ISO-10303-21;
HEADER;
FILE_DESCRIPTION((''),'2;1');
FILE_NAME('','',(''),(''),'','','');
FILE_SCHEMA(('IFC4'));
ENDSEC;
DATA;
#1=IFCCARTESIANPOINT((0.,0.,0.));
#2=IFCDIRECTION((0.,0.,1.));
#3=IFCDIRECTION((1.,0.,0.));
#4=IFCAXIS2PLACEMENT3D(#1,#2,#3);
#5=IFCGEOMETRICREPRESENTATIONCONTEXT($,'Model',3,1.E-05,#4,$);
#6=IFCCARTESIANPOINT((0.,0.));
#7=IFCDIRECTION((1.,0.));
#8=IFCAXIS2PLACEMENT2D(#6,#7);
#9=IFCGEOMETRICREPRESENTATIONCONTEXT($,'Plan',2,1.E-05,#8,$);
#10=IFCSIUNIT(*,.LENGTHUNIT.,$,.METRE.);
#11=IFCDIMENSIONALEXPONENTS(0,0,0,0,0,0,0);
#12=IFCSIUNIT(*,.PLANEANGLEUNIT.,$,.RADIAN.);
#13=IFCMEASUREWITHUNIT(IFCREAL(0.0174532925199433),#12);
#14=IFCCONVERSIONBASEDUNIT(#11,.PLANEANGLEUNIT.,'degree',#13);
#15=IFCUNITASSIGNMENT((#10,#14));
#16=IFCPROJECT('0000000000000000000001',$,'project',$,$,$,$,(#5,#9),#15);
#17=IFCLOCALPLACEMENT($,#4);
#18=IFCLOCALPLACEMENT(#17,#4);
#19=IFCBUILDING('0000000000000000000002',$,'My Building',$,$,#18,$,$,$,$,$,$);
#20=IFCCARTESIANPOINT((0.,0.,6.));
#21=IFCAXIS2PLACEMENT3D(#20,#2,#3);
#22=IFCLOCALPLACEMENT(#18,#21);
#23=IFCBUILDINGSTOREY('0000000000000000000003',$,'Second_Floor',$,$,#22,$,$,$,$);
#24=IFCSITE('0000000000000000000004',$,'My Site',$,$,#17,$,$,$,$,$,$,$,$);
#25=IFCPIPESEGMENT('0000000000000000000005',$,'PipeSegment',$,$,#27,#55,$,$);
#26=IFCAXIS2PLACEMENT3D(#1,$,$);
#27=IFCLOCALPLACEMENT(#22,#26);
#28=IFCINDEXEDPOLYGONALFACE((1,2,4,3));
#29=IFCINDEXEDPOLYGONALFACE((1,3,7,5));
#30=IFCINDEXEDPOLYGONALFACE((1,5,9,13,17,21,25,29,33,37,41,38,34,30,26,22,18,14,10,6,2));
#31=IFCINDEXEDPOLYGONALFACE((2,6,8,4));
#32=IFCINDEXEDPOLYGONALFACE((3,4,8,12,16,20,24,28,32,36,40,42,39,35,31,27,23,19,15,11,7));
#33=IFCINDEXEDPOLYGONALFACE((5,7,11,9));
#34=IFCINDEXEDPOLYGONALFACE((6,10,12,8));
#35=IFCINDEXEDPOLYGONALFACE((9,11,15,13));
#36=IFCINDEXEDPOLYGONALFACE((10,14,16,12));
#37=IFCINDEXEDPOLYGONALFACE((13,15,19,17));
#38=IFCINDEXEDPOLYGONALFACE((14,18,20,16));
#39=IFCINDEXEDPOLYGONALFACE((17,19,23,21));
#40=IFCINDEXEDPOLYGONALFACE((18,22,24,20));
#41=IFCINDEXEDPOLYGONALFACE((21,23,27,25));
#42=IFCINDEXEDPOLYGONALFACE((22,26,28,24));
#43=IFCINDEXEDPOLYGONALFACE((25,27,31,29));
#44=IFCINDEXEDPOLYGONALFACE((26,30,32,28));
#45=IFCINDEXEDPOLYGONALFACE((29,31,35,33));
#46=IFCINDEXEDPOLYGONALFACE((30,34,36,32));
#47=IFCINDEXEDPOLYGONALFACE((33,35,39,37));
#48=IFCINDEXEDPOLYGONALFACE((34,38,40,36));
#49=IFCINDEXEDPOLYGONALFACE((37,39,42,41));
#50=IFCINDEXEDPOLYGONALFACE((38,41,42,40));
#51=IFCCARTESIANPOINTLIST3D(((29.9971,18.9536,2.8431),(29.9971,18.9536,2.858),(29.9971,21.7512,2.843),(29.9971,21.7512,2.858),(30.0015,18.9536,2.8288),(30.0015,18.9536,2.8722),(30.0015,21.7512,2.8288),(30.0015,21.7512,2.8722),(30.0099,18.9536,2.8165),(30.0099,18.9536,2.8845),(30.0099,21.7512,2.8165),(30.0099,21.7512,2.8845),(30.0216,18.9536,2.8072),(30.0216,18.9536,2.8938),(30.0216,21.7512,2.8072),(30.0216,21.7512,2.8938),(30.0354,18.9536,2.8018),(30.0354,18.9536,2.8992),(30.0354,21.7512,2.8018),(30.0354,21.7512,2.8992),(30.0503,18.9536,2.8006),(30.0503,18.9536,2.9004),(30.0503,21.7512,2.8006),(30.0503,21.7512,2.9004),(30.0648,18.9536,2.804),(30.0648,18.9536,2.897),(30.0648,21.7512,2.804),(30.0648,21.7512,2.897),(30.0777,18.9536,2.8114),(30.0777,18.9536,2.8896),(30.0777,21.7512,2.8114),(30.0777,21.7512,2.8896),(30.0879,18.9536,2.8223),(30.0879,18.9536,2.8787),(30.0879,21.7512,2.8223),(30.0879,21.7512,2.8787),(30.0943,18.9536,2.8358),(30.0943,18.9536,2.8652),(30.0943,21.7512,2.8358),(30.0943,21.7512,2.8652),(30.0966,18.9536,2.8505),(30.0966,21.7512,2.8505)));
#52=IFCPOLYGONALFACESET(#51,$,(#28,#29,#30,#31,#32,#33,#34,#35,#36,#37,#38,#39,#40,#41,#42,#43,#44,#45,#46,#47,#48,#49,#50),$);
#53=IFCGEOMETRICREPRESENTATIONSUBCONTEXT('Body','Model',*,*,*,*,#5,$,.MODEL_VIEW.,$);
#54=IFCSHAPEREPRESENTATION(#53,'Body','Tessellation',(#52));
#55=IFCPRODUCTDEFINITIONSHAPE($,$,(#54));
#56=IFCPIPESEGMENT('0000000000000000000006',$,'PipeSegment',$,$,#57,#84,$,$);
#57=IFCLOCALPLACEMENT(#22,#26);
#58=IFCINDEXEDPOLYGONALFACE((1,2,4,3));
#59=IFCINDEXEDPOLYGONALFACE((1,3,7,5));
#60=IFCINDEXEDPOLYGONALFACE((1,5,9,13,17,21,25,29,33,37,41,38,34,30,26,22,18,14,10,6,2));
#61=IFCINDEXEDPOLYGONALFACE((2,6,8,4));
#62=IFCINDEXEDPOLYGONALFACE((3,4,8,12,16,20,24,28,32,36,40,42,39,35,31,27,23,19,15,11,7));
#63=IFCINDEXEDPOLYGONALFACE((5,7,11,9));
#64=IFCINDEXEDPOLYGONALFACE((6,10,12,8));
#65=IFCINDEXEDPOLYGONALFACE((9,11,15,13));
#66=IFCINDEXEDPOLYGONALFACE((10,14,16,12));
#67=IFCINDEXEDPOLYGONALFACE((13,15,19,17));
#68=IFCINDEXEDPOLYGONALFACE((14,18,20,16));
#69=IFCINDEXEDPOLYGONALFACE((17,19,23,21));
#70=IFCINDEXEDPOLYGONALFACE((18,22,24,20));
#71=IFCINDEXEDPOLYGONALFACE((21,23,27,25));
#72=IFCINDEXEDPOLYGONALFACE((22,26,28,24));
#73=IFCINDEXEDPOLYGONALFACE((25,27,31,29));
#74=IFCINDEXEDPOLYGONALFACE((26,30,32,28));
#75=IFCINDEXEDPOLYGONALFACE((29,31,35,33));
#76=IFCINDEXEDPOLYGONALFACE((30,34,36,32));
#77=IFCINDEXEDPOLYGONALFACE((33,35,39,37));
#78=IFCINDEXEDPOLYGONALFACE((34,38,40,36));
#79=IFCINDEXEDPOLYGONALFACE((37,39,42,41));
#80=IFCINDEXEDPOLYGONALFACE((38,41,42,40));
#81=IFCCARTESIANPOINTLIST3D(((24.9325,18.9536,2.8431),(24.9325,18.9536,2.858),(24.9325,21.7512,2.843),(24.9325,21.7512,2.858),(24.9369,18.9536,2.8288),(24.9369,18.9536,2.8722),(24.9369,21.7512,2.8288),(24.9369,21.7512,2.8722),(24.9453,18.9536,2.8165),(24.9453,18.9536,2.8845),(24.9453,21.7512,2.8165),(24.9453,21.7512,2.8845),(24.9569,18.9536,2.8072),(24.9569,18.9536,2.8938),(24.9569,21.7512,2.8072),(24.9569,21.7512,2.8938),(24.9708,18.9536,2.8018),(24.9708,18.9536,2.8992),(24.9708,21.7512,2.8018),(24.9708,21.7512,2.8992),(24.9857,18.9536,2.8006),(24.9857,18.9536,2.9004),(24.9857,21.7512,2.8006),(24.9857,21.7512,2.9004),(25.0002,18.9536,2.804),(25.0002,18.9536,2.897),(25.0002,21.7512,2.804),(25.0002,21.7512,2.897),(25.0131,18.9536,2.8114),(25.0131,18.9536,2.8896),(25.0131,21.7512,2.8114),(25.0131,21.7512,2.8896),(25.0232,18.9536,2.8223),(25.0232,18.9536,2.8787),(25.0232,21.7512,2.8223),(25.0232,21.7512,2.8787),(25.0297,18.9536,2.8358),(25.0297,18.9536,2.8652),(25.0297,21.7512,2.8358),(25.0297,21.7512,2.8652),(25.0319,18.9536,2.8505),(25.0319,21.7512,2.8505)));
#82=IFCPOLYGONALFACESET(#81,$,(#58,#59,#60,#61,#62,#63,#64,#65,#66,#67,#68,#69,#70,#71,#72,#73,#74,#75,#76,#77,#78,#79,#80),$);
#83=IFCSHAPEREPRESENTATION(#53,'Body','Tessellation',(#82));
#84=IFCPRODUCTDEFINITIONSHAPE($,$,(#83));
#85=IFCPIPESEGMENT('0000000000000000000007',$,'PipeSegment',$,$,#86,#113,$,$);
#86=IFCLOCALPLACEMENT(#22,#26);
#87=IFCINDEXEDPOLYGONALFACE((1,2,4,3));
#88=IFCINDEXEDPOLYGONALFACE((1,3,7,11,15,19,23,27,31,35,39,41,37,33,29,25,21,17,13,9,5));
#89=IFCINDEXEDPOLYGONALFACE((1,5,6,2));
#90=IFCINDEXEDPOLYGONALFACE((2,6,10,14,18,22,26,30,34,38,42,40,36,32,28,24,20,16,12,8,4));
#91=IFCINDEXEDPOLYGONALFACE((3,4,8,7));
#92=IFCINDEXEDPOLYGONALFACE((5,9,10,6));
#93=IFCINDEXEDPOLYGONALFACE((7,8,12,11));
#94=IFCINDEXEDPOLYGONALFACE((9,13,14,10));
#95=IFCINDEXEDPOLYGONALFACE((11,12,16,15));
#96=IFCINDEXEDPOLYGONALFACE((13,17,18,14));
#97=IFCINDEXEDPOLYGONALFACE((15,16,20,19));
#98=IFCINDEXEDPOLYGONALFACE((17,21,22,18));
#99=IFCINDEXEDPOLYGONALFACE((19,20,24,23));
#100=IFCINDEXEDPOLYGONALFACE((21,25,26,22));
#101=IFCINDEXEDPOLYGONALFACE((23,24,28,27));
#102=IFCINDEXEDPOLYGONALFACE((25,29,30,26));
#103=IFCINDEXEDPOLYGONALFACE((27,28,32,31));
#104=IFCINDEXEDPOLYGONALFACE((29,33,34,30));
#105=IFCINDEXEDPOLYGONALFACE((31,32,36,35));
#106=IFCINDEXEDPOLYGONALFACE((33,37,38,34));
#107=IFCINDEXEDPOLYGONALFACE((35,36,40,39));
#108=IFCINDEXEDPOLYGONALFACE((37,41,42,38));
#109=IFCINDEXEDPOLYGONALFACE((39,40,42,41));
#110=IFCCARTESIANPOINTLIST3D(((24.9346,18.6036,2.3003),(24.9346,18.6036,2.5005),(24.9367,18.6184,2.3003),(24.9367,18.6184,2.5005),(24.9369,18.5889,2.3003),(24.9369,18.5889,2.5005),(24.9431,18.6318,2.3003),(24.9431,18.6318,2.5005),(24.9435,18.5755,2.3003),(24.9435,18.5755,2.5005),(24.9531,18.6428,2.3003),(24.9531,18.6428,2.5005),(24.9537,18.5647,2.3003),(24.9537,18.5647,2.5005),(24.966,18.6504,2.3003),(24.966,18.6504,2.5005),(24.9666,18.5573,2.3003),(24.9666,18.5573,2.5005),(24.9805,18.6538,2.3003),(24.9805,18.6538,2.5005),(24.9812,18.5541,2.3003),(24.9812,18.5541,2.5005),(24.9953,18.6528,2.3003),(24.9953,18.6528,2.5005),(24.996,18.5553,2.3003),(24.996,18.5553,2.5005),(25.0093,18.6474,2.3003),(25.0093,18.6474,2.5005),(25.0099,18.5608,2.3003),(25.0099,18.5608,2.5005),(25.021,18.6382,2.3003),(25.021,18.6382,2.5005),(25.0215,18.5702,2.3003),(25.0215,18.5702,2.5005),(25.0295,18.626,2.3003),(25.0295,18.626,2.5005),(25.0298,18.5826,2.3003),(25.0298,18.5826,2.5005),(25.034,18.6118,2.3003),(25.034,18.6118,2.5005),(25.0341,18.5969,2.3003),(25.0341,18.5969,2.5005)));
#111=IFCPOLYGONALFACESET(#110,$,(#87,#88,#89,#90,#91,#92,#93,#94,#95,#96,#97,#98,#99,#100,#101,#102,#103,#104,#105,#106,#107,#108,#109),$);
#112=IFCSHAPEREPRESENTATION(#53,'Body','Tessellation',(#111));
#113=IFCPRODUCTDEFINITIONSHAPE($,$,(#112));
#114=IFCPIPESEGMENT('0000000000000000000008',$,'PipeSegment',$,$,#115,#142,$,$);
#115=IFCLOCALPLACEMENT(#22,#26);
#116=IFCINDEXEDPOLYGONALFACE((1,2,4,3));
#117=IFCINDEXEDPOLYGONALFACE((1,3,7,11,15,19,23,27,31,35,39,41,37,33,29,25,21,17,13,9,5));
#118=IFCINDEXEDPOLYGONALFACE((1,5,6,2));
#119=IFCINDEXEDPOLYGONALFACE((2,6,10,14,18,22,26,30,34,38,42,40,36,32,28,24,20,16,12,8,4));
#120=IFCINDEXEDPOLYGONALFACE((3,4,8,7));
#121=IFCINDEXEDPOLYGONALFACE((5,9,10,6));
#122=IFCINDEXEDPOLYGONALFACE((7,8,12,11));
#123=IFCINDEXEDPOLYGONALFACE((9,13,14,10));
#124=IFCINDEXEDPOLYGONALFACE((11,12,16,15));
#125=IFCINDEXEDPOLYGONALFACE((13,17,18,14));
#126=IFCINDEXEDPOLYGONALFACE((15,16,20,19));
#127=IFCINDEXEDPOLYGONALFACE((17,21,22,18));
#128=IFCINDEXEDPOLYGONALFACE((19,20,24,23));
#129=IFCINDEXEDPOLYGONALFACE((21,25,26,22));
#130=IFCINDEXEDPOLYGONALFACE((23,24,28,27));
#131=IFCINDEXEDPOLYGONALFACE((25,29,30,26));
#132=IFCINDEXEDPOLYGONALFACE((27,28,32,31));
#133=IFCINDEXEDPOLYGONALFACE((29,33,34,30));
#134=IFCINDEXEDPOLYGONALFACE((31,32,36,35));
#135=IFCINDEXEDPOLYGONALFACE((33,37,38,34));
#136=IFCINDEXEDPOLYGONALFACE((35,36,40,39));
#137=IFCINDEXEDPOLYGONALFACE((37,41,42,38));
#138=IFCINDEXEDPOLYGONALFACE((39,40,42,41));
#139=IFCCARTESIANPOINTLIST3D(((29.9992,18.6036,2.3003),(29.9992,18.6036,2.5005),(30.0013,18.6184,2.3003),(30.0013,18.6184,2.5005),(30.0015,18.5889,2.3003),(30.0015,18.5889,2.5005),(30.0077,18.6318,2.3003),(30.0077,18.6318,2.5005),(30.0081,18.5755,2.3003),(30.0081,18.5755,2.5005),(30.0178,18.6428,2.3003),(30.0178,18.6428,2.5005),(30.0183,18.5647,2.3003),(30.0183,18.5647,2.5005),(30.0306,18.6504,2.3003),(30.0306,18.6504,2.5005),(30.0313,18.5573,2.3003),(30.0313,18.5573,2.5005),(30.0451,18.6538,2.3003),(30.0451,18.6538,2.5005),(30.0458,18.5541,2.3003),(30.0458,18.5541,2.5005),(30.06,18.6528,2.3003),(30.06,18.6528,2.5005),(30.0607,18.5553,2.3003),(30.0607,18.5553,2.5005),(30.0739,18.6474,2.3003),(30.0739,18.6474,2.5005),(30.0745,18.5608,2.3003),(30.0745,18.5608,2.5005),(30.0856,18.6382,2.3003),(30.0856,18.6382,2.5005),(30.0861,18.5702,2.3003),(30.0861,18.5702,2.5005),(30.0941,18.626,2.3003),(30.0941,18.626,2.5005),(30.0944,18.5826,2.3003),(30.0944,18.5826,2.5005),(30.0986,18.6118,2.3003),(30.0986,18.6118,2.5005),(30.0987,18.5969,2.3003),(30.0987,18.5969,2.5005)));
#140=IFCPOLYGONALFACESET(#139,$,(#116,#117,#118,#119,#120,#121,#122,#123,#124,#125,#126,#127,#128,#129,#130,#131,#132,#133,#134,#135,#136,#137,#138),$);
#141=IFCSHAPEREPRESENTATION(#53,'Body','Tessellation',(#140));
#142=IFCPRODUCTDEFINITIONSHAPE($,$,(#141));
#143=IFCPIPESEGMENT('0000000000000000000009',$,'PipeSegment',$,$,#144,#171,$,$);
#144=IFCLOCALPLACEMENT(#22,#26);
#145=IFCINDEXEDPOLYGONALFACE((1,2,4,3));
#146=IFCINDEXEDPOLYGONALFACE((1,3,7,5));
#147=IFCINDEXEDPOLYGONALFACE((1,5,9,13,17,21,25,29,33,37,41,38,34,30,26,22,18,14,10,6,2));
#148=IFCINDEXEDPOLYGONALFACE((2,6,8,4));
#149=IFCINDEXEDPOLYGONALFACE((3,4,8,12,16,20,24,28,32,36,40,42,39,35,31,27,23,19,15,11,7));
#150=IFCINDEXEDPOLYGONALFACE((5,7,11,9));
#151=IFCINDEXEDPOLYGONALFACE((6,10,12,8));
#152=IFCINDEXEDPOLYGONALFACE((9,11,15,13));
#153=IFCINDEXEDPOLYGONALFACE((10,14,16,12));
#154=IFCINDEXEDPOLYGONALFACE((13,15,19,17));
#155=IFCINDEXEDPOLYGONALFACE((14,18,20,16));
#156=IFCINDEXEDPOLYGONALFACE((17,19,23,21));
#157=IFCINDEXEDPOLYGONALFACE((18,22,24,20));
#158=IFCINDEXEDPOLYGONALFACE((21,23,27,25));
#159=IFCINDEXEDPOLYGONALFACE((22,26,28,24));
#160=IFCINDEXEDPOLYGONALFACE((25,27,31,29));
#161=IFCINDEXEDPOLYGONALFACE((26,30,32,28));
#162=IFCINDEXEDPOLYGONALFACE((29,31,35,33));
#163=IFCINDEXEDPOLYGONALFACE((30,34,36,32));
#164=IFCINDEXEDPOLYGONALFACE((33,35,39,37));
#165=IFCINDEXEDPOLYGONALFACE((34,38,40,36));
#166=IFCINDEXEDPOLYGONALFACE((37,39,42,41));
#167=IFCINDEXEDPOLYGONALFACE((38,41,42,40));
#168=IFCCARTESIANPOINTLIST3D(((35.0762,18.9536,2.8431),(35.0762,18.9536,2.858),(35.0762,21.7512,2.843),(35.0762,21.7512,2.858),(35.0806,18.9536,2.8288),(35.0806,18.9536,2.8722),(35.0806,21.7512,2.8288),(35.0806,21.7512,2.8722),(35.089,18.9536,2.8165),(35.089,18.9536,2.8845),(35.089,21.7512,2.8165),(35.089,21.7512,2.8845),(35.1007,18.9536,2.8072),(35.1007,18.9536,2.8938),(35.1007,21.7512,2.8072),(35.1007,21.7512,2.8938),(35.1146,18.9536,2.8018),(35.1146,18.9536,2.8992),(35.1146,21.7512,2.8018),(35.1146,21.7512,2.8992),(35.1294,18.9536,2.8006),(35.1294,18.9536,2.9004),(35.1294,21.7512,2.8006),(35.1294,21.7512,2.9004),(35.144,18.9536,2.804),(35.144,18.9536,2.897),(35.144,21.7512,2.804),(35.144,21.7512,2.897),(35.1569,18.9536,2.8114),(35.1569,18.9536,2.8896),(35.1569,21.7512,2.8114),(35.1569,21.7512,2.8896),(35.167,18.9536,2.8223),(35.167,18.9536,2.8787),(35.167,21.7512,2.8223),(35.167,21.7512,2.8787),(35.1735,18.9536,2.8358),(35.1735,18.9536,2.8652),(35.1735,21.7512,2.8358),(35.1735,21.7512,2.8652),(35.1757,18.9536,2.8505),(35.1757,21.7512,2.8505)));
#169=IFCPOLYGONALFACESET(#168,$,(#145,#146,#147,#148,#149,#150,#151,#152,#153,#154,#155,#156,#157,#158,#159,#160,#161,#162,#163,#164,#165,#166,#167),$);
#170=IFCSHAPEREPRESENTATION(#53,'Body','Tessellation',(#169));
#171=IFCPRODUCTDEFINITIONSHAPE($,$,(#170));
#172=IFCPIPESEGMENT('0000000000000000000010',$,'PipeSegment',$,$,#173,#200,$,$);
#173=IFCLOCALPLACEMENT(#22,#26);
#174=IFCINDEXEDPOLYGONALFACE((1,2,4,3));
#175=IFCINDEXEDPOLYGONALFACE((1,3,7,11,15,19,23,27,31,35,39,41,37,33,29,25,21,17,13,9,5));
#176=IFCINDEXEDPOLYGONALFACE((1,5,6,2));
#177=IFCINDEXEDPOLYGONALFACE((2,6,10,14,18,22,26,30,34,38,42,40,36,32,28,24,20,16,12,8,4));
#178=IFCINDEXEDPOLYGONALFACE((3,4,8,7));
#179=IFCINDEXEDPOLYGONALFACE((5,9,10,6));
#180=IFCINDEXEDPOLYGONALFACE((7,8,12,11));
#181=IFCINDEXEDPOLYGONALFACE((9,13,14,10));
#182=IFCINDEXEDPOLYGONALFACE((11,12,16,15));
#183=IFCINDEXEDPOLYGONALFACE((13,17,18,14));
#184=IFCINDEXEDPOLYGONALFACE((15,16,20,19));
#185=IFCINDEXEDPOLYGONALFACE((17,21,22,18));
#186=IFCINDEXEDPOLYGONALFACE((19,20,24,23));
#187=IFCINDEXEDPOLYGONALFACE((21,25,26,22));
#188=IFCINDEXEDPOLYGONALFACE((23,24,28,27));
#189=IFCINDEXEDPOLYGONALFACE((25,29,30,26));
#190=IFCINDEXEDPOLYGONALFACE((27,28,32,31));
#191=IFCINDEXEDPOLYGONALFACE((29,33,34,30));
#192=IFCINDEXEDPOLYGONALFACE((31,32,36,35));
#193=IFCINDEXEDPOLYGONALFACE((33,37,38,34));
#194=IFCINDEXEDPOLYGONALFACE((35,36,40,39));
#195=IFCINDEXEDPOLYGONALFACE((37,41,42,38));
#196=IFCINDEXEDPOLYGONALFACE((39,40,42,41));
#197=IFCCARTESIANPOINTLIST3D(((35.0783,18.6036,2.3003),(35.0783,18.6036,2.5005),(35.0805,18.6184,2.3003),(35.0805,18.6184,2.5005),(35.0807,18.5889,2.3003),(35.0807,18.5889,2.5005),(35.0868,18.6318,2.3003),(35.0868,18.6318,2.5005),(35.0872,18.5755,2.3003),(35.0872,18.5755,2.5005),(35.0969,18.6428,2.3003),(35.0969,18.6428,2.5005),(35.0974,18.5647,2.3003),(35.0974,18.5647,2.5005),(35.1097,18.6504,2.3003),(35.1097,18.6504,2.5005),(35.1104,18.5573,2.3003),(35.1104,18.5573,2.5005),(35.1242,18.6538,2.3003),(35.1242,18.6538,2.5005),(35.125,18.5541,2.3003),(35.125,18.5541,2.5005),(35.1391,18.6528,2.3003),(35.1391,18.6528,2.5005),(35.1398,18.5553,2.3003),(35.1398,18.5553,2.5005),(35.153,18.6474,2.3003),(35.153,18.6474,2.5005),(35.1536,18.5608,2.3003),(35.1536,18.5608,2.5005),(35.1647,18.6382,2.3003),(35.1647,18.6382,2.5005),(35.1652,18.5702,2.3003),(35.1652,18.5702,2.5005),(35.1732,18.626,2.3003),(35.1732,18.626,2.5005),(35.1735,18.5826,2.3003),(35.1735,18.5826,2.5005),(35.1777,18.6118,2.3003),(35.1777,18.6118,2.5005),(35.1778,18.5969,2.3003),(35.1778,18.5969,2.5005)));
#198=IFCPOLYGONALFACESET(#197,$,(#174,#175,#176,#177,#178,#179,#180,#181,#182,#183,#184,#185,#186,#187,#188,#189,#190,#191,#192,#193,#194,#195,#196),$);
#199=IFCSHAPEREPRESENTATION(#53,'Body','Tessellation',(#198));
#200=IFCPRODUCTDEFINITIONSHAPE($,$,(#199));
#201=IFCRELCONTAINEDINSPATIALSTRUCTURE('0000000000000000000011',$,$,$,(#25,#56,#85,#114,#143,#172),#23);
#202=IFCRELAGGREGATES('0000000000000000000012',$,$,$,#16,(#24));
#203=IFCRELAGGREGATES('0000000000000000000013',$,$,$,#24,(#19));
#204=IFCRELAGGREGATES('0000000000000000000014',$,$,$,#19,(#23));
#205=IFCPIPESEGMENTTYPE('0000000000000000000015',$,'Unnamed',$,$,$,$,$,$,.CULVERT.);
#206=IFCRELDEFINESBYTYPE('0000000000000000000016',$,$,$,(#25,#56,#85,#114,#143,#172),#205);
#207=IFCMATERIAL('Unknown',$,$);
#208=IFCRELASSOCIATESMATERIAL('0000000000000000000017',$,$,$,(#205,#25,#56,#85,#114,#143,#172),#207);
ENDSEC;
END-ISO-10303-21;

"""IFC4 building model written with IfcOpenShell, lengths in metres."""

from ifc_helpers import new_model, entity, si_unit, converted_unit, frame, origin_with_axes, origin_2d_with_axis, place, context, subcontext, project, spatial, circle, extrude, material, material_profile, profile_set, profile_usage, type_object, element, save


model = new_model("IFC4")

# Units and contexts
model_context = context("Model", 3, precision=1e-05, world=origin_with_axes())
plan_context = context("Plan", 2, precision=1e-05, world=origin_2d_with_axis())
body_context_1 = subcontext(model_context, "Body", "Model", "MODEL_VIEW")
ifc_project = project(units=[si_unit("LENGTHUNIT", "METRE"), converted_unit("PLANEANGLEUNIT", "degree", entity("IfcReal", 0.0174532925199433), si_unit("PLANEANGLEUNIT", "RADIAN"), dimensions=[0, 0, 0, 0, 0, 0, 0])], contexts=[model_context, plan_context])

# Site, building, storey
site_placement = place(None, origin_with_axes())
site = spatial("IfcSite", under=ifc_project, at=site_placement, Name="My Site")
building_placement = place(site_placement, origin_with_axes())
building = spatial("IfcBuilding", under=site, at=building_placement, Name="My Building")
storey_placement = place(building_placement, frame((0.0, 0.0, 6.0), z_axis=(0.0, 0.0, 1.0), x_axis=(1.0, 0.0, 0.0)))
storey = spatial("IfcBuildingStorey", under=building, at=storey_placement, Name="Second_Floor")

# Shared definitions
ifc_material = material(Name="Unknown")

# Pipe segments
ifc_material_profile_1 = material_profile(ifc_material, circle(Radius=0.05))
ifc_profile_set_1 = profile_set([ifc_material_profile_1])
ifc_profile_usage_1 = profile_usage(ifc_profile_set_1, cardinal=5)
pipe_segment_type = type_object("IfcPipeSegmentType", Name="Unnamed", PredefinedType="CULVERT", material=ifc_profile_set_1)
pipe_segment_1_placement = place(storey_placement, frame((30.0466, 21.7512, 2.8505), z_axis=(0.0, -1.0, 0.0), x_axis=(1.0, 0.0, 0.0)))
element("IfcPipeSegment", 1, at=pipe_segment_1_placement, inside=storey, type_object=pipe_segment_type, material=ifc_profile_usage_1, Name="PipeSegment", context=body_context_1, shape_type="SweptSolid", body=[
    extrude(circle(Radius=0.05), origin_with_axes(), (0.0, 0.0, 1.0), 2.7976),
])
ifc_profile_usage_2 = profile_usage(ifc_profile_set_1, cardinal=5)
pipe_segment_2_placement = place(storey_placement, frame((24.9819, 21.7512, 2.8505), z_axis=(0.0, -1.0, 0.0), x_axis=(1.0, 0.0, 0.0)))
element("IfcPipeSegment", 2, at=pipe_segment_2_placement, inside=storey, type_object=pipe_segment_type, material=ifc_profile_usage_2, Name="PipeSegment", context=body_context_1, shape_type="SweptSolid", body=[
    extrude(circle(Radius=0.05), origin_with_axes(), (0.0, 0.0, 1.0), 2.7976),
])
ifc_profile_usage_3 = profile_usage(ifc_profile_set_1, cardinal=5)
pipe_segment_3_placement = place(storey_placement, frame((24.9846, 18.604, 2.5005), z_axis=(-0.000001, 0.0, -1.0), x_axis=(-0.999975, -0.007084, 0.000001)))
element("IfcPipeSegment", 3, at=pipe_segment_3_placement, inside=storey, type_object=pipe_segment_type, material=ifc_profile_usage_3, Name="PipeSegment", context=body_context_1, shape_type="SweptSolid", body=[
    extrude(circle(Radius=0.05), origin_with_axes(), (0.0, 0.0, 1.0), 0.2002),
])
ifc_profile_usage_4 = profile_usage(ifc_profile_set_1, cardinal=5)
pipe_segment_4_placement = place(storey_placement, frame((30.0492, 18.604, 2.5005), z_axis=(-0.000001, 0.0, -1.0), x_axis=(-0.999975, -0.007084, 0.000001)))
element("IfcPipeSegment", 4, at=pipe_segment_4_placement, inside=storey, type_object=pipe_segment_type, material=ifc_profile_usage_4, Name="PipeSegment", context=body_context_1, shape_type="SweptSolid", body=[
    extrude(circle(Radius=0.05), origin_with_axes(), (0.0, 0.0, 1.0), 0.2002),
])
ifc_profile_usage_5 = profile_usage(ifc_profile_set_1, cardinal=5)
pipe_segment_5_placement = place(storey_placement, frame((35.1257, 21.7512, 2.8505), z_axis=(0.0, -1.0, 0.0), x_axis=(1.0, 0.0, 0.0)))
element("IfcPipeSegment", 5, at=pipe_segment_5_placement, inside=storey, type_object=pipe_segment_type, material=ifc_profile_usage_5, Name="PipeSegment", context=body_context_1, shape_type="SweptSolid", body=[
    extrude(circle(Radius=0.05), origin_with_axes(), (0.0, 0.0, 1.0), 2.7976),
])
ifc_profile_usage_6 = profile_usage(ifc_profile_set_1, cardinal=5)
pipe_segment_6_placement = place(storey_placement, frame((35.1283, 18.604, 2.5005), z_axis=(-0.000001, 0.0, -1.0), x_axis=(-0.999975, -0.007084, 0.000001)))
element("IfcPipeSegment", 6, at=pipe_segment_6_placement, inside=storey, type_object=pipe_segment_type, material=ifc_profile_usage_6, Name="PipeSegment", context=body_context_1, shape_type="SweptSolid", body=[
    extrude(circle(Radius=0.05), origin_with_axes(), (0.0, 0.0, 1.0), 0.2002),
])

save(model, "model.ifc")
